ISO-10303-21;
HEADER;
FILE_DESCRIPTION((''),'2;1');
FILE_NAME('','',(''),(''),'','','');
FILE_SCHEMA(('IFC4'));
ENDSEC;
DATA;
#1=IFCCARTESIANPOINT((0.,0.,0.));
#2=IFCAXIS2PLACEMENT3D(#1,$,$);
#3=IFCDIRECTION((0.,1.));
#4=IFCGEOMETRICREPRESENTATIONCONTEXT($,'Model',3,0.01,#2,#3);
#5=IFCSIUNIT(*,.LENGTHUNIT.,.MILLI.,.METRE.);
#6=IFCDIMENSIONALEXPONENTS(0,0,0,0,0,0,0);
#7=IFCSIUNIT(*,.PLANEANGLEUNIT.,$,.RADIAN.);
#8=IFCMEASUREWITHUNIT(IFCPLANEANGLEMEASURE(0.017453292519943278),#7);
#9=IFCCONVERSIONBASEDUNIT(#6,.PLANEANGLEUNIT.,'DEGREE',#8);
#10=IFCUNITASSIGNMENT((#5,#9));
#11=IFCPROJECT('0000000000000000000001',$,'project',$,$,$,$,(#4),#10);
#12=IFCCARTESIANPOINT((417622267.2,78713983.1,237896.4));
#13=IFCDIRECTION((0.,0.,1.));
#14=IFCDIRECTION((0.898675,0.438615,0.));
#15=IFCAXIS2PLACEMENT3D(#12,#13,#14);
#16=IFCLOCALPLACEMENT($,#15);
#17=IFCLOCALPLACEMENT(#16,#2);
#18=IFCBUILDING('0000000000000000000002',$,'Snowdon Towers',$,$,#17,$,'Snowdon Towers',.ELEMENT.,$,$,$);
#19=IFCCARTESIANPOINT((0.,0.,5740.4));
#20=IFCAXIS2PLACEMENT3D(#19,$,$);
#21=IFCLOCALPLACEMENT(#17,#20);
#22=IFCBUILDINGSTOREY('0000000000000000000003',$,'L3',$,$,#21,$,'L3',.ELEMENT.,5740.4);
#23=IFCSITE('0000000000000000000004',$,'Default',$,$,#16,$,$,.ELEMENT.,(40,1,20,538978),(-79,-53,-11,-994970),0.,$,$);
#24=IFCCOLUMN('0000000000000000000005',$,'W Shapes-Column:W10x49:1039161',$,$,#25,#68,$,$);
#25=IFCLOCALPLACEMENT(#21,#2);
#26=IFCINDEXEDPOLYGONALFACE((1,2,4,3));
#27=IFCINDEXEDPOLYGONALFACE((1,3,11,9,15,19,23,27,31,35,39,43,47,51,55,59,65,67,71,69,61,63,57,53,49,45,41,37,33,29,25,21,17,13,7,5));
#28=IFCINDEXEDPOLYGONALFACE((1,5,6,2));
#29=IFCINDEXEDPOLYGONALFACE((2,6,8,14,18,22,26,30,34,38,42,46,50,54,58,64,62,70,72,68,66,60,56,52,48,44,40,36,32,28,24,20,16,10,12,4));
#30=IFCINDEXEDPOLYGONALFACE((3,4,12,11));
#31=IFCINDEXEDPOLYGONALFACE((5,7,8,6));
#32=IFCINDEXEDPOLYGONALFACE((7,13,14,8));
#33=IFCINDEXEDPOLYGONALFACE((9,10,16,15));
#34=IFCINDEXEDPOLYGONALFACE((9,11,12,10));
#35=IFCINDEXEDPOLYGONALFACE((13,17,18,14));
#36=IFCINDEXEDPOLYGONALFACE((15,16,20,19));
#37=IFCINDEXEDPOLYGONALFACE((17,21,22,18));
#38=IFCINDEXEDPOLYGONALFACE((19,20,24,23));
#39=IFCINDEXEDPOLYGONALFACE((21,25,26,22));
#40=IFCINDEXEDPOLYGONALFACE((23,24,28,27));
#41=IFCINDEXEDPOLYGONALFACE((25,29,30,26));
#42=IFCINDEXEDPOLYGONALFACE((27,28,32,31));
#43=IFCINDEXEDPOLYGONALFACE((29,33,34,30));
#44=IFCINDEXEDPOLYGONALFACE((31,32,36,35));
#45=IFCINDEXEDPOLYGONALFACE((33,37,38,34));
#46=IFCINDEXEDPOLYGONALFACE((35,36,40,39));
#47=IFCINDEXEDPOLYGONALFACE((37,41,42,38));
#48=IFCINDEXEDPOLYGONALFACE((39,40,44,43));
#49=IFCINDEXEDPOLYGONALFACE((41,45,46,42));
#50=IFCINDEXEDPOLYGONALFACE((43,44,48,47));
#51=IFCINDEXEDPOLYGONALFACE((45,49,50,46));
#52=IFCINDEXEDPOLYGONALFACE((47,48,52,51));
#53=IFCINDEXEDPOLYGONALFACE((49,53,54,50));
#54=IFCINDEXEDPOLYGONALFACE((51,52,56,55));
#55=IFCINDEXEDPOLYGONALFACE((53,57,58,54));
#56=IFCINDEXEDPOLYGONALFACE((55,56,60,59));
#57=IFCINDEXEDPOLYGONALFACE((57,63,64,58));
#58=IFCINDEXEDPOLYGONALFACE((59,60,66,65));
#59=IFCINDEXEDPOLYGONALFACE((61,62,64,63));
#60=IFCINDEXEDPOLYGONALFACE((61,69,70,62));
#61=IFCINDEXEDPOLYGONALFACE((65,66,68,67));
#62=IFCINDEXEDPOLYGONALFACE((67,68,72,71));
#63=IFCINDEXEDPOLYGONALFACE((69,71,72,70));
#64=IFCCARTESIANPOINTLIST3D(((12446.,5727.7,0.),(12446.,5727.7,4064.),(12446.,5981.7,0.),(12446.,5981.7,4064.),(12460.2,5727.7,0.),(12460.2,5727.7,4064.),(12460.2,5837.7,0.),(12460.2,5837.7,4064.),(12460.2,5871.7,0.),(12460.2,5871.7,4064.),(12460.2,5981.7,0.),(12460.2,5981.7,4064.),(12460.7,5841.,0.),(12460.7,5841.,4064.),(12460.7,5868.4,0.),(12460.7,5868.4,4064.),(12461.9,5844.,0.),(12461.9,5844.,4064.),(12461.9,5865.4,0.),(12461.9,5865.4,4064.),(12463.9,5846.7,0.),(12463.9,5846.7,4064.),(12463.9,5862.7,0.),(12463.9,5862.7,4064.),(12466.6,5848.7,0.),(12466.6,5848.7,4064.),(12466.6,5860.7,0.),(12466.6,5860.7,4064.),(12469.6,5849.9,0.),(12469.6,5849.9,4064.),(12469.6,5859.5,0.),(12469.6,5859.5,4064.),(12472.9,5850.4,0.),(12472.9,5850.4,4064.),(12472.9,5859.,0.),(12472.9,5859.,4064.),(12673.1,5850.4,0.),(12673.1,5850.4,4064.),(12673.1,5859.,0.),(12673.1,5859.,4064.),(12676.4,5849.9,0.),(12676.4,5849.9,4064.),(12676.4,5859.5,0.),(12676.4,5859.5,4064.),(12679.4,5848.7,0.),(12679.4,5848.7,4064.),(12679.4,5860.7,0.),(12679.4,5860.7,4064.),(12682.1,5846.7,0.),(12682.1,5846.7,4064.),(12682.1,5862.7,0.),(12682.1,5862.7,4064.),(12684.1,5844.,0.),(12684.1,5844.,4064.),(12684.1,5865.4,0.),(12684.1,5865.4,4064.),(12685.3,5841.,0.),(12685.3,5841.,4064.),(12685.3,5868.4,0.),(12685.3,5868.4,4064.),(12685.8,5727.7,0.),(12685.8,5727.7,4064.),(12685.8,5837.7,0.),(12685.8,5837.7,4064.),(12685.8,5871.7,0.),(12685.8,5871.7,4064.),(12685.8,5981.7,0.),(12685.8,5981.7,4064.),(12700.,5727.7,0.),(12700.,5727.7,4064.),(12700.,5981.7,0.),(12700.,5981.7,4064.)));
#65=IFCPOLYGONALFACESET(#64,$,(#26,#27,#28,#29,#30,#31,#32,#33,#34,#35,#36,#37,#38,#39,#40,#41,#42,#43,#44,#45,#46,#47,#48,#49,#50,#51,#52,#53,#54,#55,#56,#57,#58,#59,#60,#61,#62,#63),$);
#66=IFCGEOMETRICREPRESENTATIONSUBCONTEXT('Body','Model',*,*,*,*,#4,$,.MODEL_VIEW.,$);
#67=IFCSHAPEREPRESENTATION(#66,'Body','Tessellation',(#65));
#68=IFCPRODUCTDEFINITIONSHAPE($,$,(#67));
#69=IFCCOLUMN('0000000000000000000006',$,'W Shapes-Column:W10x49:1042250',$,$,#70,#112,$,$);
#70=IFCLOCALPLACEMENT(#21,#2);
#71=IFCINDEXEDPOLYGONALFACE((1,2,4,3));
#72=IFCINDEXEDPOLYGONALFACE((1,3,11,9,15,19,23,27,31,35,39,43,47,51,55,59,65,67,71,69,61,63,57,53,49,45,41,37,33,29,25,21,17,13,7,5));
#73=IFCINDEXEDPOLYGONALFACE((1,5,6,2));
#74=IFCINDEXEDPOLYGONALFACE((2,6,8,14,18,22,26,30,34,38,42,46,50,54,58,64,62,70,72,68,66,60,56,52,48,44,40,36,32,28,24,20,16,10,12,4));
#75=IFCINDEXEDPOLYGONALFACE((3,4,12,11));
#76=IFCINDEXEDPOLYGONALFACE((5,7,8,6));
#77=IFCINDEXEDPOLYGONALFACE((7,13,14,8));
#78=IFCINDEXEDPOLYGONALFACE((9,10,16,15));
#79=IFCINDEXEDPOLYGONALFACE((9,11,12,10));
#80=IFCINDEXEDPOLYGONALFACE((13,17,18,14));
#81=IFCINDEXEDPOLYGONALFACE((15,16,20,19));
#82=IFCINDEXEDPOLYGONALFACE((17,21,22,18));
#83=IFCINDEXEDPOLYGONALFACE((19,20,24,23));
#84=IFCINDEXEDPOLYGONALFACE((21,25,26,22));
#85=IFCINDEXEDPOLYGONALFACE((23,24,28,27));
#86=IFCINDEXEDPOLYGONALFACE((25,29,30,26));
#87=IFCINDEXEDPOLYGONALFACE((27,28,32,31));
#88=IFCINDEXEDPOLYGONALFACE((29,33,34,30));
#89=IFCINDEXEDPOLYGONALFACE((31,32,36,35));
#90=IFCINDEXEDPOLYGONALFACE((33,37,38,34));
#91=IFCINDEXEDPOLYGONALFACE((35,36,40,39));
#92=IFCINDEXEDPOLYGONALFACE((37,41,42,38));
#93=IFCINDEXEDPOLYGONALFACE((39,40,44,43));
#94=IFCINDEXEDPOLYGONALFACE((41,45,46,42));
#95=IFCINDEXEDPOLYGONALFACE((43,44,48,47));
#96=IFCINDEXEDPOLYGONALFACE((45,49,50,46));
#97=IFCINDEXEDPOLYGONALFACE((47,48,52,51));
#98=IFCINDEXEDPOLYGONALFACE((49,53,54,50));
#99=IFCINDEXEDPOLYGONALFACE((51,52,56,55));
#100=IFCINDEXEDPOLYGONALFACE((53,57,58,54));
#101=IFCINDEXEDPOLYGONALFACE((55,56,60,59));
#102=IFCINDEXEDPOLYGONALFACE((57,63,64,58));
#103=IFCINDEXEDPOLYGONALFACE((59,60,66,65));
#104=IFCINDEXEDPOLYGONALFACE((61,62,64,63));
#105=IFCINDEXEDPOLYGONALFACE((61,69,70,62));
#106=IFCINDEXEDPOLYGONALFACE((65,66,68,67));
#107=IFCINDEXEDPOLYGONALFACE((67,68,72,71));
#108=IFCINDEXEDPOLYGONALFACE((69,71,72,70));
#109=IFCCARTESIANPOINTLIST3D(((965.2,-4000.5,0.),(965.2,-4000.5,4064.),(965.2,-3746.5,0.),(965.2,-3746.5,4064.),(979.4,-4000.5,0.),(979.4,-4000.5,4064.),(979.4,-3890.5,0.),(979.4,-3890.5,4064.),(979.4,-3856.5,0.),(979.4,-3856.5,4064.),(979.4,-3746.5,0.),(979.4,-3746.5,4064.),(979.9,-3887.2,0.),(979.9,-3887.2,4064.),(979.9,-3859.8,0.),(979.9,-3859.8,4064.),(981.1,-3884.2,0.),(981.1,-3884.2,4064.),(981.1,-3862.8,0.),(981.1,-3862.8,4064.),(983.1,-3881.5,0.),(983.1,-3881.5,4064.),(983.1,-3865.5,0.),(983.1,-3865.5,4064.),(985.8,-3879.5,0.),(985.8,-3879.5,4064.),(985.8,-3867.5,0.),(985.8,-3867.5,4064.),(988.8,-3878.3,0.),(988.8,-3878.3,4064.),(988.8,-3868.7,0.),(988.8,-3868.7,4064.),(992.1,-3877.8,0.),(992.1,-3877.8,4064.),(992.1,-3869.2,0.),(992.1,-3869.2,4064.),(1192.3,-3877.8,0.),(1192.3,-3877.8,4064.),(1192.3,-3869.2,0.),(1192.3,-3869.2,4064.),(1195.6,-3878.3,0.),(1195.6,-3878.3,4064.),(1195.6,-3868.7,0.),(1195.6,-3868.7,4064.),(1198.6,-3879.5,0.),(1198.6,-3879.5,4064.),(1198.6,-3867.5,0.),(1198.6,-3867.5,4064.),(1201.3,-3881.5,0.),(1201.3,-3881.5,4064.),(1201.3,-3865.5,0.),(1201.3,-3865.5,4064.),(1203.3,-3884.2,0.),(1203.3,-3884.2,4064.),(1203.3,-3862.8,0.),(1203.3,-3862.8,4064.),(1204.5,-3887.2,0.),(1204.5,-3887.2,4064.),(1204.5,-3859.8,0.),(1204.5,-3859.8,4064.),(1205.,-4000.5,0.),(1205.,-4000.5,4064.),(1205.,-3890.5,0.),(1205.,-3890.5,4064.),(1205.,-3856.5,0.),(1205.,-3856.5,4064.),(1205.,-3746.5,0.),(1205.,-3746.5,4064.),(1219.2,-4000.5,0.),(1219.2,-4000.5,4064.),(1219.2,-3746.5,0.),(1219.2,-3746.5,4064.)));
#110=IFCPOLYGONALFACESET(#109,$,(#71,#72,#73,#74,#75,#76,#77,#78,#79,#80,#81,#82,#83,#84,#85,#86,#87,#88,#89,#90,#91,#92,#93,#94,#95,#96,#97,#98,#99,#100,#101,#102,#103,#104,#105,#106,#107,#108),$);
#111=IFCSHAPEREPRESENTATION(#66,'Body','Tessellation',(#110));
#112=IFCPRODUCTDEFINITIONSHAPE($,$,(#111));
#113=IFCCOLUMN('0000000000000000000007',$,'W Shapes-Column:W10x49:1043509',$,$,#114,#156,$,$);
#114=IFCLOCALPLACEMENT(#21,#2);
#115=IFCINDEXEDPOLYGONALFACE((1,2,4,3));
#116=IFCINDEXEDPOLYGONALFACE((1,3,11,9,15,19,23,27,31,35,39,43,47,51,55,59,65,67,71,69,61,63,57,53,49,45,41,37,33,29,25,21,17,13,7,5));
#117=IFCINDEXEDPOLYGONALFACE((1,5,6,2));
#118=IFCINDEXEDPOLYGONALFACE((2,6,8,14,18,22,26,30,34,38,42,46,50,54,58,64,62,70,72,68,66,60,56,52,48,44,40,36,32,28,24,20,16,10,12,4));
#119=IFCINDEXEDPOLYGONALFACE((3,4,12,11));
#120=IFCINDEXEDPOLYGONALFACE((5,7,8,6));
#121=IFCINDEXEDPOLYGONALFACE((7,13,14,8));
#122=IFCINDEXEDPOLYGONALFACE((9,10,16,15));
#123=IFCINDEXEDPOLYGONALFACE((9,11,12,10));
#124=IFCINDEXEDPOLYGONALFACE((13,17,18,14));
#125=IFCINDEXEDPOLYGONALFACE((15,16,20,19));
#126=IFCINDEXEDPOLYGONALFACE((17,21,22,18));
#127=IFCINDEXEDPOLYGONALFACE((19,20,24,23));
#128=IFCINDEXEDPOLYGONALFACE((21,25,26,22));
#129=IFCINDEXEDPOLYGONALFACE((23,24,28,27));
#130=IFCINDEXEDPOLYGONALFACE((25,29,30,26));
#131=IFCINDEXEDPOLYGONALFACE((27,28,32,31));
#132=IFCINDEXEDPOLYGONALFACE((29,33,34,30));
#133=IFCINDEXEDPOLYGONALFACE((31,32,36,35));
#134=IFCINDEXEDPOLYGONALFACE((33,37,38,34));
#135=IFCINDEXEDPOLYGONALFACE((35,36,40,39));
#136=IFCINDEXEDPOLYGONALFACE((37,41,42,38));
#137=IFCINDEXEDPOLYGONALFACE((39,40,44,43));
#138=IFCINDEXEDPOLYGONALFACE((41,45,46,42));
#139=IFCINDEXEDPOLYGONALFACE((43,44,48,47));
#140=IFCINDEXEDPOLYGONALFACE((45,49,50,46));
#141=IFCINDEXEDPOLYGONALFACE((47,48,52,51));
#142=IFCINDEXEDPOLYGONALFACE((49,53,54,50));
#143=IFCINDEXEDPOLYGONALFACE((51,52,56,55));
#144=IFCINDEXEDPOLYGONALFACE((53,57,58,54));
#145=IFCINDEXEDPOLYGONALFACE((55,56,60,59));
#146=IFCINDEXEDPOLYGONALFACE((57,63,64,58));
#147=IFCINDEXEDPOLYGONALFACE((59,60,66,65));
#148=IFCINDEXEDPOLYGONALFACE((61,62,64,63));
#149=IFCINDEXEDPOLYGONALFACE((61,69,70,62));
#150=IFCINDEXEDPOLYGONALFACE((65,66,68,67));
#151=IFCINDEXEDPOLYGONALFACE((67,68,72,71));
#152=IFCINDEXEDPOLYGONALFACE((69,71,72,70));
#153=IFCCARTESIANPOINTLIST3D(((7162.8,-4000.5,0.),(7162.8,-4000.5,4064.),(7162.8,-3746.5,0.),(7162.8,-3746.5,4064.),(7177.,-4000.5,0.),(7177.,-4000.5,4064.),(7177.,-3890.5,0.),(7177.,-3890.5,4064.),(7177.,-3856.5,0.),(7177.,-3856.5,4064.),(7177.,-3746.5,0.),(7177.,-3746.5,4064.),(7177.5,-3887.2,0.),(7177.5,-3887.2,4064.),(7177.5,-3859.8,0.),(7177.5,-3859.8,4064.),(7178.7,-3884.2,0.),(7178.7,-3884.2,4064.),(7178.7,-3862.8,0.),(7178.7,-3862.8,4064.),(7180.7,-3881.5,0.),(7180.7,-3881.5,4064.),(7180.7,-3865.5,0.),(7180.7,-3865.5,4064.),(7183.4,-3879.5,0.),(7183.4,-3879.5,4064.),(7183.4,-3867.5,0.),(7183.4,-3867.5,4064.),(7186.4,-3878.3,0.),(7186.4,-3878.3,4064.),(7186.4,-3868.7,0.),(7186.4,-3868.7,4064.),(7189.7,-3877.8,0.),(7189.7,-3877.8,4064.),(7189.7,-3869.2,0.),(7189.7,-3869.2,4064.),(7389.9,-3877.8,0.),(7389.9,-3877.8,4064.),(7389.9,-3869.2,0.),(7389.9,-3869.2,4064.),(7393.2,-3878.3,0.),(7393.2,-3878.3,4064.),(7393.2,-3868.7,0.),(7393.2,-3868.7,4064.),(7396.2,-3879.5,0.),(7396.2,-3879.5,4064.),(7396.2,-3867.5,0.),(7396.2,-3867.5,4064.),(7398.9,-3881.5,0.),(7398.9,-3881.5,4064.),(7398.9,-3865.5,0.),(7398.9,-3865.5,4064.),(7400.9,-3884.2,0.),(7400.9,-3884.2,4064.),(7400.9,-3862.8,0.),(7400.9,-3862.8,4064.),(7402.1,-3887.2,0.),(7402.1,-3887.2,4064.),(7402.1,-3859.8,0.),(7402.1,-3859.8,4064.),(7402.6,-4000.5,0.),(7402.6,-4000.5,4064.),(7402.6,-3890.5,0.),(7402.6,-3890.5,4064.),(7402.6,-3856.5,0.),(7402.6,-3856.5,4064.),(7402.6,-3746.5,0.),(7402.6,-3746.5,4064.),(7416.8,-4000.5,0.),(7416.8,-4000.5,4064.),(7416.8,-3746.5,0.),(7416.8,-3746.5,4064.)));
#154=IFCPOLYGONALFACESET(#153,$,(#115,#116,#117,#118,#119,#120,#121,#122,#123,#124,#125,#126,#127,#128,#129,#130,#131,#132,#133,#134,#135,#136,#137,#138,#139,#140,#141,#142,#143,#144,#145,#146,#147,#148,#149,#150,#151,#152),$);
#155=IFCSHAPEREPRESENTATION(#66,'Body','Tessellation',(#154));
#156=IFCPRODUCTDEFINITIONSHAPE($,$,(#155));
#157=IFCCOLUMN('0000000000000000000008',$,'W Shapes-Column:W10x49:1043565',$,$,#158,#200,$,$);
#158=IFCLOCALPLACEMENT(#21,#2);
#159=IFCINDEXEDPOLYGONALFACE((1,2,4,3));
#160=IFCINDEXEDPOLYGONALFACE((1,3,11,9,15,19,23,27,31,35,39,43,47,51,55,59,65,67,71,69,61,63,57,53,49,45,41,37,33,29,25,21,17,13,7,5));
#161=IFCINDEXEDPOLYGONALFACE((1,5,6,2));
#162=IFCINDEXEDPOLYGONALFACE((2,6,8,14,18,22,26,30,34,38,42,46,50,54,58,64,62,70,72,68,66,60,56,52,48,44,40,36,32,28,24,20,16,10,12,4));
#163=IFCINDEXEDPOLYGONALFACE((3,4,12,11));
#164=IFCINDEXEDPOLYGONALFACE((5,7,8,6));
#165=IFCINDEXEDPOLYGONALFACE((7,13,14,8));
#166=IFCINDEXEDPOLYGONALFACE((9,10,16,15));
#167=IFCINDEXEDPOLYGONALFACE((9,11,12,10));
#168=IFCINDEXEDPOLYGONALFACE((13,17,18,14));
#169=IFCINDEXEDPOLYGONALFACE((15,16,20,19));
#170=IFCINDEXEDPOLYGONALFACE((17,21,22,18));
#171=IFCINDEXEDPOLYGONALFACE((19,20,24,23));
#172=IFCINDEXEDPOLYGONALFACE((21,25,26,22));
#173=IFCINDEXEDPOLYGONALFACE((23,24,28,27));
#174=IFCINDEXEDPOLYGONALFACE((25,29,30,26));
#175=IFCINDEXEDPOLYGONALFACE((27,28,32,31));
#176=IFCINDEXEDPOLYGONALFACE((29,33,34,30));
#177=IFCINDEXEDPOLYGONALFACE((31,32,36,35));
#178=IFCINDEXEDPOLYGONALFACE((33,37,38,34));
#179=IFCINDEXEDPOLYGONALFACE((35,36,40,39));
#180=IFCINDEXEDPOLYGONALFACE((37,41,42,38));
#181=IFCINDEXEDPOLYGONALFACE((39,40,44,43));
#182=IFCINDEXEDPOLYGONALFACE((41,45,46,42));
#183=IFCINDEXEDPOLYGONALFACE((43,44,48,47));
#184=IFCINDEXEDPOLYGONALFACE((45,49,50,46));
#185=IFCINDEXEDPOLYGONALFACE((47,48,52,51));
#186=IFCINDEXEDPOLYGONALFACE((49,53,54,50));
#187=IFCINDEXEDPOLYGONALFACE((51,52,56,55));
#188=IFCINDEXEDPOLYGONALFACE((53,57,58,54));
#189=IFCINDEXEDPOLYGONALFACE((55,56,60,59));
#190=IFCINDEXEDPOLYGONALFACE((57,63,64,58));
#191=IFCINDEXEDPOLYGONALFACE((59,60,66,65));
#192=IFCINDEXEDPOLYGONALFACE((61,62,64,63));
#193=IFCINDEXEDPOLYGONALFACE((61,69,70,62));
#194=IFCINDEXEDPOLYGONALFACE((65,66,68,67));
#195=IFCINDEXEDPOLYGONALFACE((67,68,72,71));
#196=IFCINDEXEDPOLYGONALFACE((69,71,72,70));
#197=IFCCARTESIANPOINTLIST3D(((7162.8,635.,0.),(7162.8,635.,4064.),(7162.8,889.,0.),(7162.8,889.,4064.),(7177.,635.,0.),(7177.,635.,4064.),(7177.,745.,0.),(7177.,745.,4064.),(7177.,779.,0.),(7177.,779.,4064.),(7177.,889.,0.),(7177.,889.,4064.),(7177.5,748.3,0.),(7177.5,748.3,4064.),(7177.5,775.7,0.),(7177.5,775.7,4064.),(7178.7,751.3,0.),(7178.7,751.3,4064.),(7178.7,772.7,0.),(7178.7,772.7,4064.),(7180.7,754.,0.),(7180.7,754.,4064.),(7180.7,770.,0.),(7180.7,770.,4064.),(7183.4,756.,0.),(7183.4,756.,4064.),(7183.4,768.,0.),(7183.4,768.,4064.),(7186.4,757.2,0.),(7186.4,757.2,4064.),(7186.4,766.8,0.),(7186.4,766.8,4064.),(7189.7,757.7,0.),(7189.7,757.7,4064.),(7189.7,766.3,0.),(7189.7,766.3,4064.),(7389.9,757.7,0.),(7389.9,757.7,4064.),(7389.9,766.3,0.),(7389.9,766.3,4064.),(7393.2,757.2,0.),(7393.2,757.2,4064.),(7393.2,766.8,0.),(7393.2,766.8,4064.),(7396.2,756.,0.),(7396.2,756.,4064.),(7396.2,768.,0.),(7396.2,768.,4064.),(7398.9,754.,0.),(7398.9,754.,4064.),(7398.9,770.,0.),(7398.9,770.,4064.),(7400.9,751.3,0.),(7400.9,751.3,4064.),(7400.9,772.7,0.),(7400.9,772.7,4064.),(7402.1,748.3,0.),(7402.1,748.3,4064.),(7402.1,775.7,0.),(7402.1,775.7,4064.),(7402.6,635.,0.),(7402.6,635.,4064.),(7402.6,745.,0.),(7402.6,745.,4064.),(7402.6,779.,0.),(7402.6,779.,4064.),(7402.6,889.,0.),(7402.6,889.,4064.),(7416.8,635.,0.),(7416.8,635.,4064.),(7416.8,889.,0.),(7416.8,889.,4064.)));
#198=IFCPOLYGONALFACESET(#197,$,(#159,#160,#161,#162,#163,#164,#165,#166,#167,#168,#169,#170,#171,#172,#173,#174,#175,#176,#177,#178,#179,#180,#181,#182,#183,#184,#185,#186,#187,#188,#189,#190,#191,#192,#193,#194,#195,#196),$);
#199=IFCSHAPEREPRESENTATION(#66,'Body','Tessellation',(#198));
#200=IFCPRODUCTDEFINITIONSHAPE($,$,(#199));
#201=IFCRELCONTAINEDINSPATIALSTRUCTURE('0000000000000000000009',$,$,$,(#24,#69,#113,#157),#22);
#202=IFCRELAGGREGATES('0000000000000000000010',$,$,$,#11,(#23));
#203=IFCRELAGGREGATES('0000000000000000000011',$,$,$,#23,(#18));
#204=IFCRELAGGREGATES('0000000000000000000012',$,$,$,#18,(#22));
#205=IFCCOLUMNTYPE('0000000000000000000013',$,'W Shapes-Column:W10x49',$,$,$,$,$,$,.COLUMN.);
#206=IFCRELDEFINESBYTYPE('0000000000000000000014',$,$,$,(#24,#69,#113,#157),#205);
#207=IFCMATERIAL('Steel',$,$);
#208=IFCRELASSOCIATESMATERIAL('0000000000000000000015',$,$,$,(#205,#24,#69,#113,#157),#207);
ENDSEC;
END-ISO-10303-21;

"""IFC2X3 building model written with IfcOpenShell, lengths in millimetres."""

from ifc_helpers import new_model, entity, si_unit, converted_unit, direction, frame, frame_2d, origin, place, context, subcontext, project, spatial, i_section, extrude, source, transform, mapped, material, type_object, type_shapes, element, save


model = new_model("IFC2X3")

# Units and contexts
model_context = context("Model", 3, precision=0.01, world=origin(), true_north=direction((0.0, 1.0)))
body_context = subcontext(model_context, "Body", "Model", "MODEL_VIEW")
ifc_project = project(units=[si_unit("LENGTHUNIT", "METRE", prefix="MILLI"), converted_unit("PLANEANGLEUNIT", "DEGREE", entity("IfcPlaneAngleMeasure", 0.017453292519943278), si_unit("PLANEANGLEUNIT", "RADIAN"), dimensions=[0, 0, 0, 0, 0, 0, 0])], contexts=[model_context])

# Site, building, storey
site_placement = place(None, frame((417622267.2, 78713983.1, 237896.4), z_axis=(0.0, 0.0, 1.0), x_axis=(0.898675, 0.438615, 0.0)))
site = spatial("IfcSite", under=ifc_project, at=site_placement, Name="Default", CompositionType="ELEMENT", RefLatitude=(40, 1, 20, 538978), RefLongitude=(-79, -53, -11, -994970), RefElevation=0.0)
building_placement = place(site_placement, origin())
building = spatial("IfcBuilding", under=site, at=building_placement, Name="Snowdon Towers", LongName="Snowdon Towers", CompositionType="ELEMENT")
storey_placement = place(building_placement, frame((0.0, 0.0, 5740.4)))
storey = spatial("IfcBuildingStorey", under=building, at=storey_placement, Name="L3", LongName="L3", CompositionType="ELEMENT", Elevation=5740.4)

# Columns
ifc_material_1 = material(Name="Steel")
column_type_1 = type_object("IfcColumnType", Name="W Shapes-Column:W10x49", PredefinedType="COLUMN", material=ifc_material_1)
shared_shape_1 = source(origin(), body_context, "Body", "SweptSolid", [
    extrude(i_section(OverallWidth=254.0, OverallDepth=254.0, WebThickness=8.6, FlangeThickness=14.2, FilletRadius=12.7, at=frame_2d((0.0, 0.0), x_axis=(1.0, 0.0))), frame((0.0, 0.0, 5740.4), z_axis=(0.0, 0.0, 1.0), x_axis=(-1.0, 0.0, 0.0)), (0.0, 0.0, 1.0), 4064.0),
])
type_shapes(column_type_1, [shared_shape_1])
for number, where, z_axis, x_axis, name in (
    (1, (12573.0, 5854.7, -5740.4), (0.0, 0.0, 1.0), (0.0, 1.0, 0.0), "W Shapes-Column:W10x49:1039161"),
    (2, (1092.2, -3873.5, -5740.4), (0.0, 0.0, 1.0), (0.0, 1.0, 0.0), "W Shapes-Column:W10x49:1042250"),
    (3, (7289.8, -3873.5, -5740.4), (0.0, 0.0, 1.0), (0.0, 1.0, 0.0), "W Shapes-Column:W10x49:1043509"),
    (4, (7289.8, 762.0, -5740.4), (0.0, 0.0, 1.0), (0.0, 1.0, 0.0), "W Shapes-Column:W10x49:1043565"),
):
    element("IfcColumn", number, at=place(storey_placement, frame(where, z_axis=z_axis, x_axis=x_axis)), inside=storey, type_object=column_type_1, material=ifc_material_1, Name=name, context=body_context, shape_type="MappedRepresentation", body=[
        mapped(shared_shape_1, transform((0.0, 0.0, 0.0), scale=1.0)),
    ])

save(model, "model.ifc")
